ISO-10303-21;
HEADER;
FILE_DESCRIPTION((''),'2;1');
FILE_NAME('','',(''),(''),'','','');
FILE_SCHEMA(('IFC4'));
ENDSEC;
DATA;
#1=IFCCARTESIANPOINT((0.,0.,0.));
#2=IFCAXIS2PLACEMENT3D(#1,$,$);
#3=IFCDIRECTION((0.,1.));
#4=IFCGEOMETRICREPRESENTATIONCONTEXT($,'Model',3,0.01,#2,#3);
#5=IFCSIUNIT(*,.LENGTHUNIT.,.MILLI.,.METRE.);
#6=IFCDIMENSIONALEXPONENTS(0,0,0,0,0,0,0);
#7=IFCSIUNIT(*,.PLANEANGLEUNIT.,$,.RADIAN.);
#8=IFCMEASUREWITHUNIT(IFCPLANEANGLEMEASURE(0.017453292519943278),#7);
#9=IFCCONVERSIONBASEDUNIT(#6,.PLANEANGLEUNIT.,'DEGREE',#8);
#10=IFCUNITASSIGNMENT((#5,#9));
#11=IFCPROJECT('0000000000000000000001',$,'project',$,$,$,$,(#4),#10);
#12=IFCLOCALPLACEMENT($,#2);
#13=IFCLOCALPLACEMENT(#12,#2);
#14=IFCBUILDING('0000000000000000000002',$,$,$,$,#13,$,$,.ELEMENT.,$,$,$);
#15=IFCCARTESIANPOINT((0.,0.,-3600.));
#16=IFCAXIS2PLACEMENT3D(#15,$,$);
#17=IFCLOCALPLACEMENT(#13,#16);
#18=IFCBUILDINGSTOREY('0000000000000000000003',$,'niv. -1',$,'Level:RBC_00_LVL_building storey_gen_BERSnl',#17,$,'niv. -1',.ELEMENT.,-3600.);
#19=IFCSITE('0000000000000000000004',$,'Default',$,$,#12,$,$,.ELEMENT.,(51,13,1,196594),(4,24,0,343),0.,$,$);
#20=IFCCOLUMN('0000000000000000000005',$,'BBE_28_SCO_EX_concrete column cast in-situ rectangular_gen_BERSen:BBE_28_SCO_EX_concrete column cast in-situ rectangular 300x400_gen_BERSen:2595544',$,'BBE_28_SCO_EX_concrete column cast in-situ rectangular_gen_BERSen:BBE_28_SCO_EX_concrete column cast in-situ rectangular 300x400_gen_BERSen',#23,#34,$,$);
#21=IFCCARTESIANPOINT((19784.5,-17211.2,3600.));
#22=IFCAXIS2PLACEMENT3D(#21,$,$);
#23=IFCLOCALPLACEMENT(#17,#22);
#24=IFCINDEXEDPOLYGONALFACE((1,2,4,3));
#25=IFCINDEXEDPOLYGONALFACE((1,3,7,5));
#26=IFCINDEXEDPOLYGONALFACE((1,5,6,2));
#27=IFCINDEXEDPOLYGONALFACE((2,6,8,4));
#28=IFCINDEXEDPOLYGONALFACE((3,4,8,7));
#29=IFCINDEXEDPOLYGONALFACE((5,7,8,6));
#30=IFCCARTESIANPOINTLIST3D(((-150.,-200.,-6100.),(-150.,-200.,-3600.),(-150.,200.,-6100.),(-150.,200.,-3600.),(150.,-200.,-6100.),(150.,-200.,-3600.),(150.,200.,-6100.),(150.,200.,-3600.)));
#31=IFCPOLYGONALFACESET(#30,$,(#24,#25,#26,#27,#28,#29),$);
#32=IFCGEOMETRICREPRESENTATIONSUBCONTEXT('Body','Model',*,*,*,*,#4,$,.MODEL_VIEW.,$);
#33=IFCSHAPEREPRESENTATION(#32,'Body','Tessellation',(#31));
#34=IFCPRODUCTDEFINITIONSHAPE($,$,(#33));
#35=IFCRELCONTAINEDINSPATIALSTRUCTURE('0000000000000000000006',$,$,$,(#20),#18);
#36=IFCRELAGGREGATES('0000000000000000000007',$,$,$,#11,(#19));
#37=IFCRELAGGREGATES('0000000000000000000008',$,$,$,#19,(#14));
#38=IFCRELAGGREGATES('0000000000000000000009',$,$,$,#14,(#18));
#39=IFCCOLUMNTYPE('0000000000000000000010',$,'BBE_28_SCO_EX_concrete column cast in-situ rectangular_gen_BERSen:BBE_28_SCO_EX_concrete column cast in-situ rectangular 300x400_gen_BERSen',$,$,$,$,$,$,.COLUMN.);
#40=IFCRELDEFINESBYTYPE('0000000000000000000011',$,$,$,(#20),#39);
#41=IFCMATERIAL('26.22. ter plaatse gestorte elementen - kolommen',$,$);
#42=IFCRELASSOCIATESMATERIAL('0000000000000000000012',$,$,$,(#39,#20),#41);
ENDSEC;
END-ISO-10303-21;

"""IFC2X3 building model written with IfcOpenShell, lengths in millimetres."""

from ifc_helpers import new_model, entity, si_unit, converted_unit, direction, frame, origin, origin_2d_with_axis, place, context, subcontext, project, spatial, rectangle, extrude, source, transform, mapped, material, type_object, type_shapes, element, save


model = new_model("IFC2X3")

# Units and contexts
model_context = context("Model", 3, precision=0.01, world=origin(), true_north=direction((0.0, 1.0)))
body_context = subcontext(model_context, "Body", "Model", "MODEL_VIEW")
ifc_project = project(units=[si_unit("LENGTHUNIT", "METRE", prefix="MILLI"), converted_unit("PLANEANGLEUNIT", "DEGREE", entity("IfcPlaneAngleMeasure", 0.017453292519943278), si_unit("PLANEANGLEUNIT", "RADIAN"), dimensions=[0, 0, 0, 0, 0, 0, 0])], contexts=[model_context])

# Site, building, storey
site_placement = place(None, origin())
site = spatial("IfcSite", under=ifc_project, at=site_placement, Name="Default", CompositionType="ELEMENT", RefLatitude=(51, 13, 1, 196594), RefLongitude=(4, 24, 0, 343), RefElevation=0.0)
building_placement = place(site_placement, origin())
building = spatial("IfcBuilding", under=site, at=building_placement, CompositionType="ELEMENT")
storey_placement = place(building_placement, frame((0.0, 0.0, -3600.0)))
storey = spatial("IfcBuildingStorey", under=building, at=storey_placement, Name="niv. -1", ObjectType="Level:RBC_00_LVL_building storey_gen_BERSnl", LongName="niv. -1", CompositionType="ELEMENT", Elevation=-3600.0)

# Column
ifc_material_1 = material(Name="26.22. ter plaatse gestorte elementen - kolommen")
column_type = type_object("IfcColumnType", Name="BBE_28_SCO_EX_concrete column cast in-situ rectangular_gen_BERSen:BBE_28_SCO_EX_concrete column cast in-situ rectangular 300x400_gen_BERSen", PredefinedType="COLUMN", material=ifc_material_1)
shared_shape = source(origin(), body_context, "Body", "SweptSolid", [
    extrude(rectangle(XDim=300.0, YDim=400.0, at=origin_2d_with_axis()), frame((0.0, 0.0, -6100.0), z_axis=(0.0, 0.0, 1.0), x_axis=(-1.0, 0.0, 0.0)), (0.0, 0.0, 1.0), 2500.0),
])
type_shapes(column_type, [shared_shape])
column_placement = place(storey_placement, frame((19784.5, -17211.2, 3600.0)))
element("IfcColumn", 1, at=column_placement, inside=storey, type_object=column_type, material=ifc_material_1, Name="BBE_28_SCO_EX_concrete column cast in-situ rectangular_gen_BERSen:BBE_28_SCO_EX_concrete column cast in-situ rectangular 300x400_gen_BERSen:2595544", ObjectType="BBE_28_SCO_EX_concrete column cast in-situ rectangular_gen_BERSen:BBE_28_SCO_EX_concrete column cast in-situ rectangular 300x400_gen_BERSen", context=body_context, shape_type="MappedRepresentation", body=[
    mapped(shared_shape, transform((0.0, 0.0, 0.0), scale=1.0)),
])

save(model, "model.ifc")
